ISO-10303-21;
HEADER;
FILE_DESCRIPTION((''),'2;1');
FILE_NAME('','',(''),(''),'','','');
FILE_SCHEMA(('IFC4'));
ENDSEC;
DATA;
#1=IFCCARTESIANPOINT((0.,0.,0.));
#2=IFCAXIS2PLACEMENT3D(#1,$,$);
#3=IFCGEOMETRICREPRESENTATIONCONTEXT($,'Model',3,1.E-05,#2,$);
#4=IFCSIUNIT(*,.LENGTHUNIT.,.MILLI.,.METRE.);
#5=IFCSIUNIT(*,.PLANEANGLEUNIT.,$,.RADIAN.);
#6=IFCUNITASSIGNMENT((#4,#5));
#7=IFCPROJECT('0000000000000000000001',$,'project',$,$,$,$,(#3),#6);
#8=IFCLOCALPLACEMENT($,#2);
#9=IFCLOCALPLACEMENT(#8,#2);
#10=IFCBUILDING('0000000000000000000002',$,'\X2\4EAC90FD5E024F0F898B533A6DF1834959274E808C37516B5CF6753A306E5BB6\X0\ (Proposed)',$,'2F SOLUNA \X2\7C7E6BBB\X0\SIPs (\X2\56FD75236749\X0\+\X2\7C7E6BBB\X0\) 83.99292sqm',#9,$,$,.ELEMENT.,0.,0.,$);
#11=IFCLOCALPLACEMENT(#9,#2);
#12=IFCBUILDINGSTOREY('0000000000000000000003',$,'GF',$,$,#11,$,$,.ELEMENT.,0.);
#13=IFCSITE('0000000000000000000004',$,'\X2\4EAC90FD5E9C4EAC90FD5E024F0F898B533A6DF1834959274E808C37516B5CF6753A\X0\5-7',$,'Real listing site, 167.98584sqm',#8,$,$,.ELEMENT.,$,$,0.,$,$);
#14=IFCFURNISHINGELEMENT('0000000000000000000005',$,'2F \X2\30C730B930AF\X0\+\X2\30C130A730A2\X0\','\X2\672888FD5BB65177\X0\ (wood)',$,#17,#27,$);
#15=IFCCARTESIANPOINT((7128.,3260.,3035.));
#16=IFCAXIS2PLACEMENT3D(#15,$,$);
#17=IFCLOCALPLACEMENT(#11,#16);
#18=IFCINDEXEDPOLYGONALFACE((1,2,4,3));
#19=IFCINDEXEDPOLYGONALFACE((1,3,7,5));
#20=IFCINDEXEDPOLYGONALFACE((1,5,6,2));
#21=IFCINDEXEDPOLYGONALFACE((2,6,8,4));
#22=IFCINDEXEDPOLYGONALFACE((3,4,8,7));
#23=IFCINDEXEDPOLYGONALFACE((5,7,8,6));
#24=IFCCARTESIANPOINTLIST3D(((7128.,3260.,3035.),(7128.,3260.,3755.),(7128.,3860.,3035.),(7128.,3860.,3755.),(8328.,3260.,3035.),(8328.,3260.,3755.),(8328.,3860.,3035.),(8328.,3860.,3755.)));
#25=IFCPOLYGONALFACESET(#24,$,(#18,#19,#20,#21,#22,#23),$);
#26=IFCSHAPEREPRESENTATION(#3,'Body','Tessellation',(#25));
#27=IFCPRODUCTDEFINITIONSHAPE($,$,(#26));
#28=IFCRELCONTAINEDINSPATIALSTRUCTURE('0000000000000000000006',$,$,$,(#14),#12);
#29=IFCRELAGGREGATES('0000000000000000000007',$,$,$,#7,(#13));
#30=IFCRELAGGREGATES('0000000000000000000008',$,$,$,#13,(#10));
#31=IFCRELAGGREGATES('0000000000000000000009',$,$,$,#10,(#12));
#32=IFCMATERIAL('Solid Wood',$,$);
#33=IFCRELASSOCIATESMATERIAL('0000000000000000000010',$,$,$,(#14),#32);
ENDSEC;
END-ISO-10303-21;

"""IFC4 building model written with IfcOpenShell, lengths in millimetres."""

from ifc_helpers import new_model, si_unit, frame, frame_2d, origin, place, context, project, spatial, rectangle, extrude, material, element, save


model = new_model("IFC4")

# Units and contexts
model_context = context("Model", 3, precision=1e-05, world=origin())
ifc_project = project(units=[si_unit("LENGTHUNIT", "METRE", prefix="MILLI"), si_unit("PLANEANGLEUNIT", "RADIAN")], contexts=[model_context])

# Site, building, storey
site_placement = place(None, origin())
site = spatial("IfcSite", under=ifc_project, at=site_placement, Name="京都府京都市伏見区深草大亀谷八島町5-7", ObjectType="Real listing site, 167.98584sqm", CompositionType="ELEMENT", RefElevation=0.0)
building_placement = place(site_placement, origin())
building = spatial("IfcBuilding", under=site, at=building_placement, Name="京都市伏見区深草大亀谷八島町の家 (Proposed)", ObjectType="2F SOLUNA 籾殻SIPs (国産杉+籾殻) 83.99292sqm", CompositionType="ELEMENT", ElevationOfRefHeight=0.0, ElevationOfTerrain=0.0)
storey_placement = place(building_placement, origin())
storey = spatial("IfcBuildingStorey", under=building, at=storey_placement, Name="GF", CompositionType="ELEMENT", Elevation=0.0)

# Shared definitions
ifc_material_1 = material(Name="Solid Wood")

# Furnishing element
furnishing_1_placement = place(storey_placement, frame((7128.0, 3260.0, 3035.0)))
element("IfcFurnishingElement", 1, at=furnishing_1_placement, inside=storey, material=ifc_material_1, Name="2F デスク+チェア", Description="木製家具 (wood)", context=model_context, shape_type="SweptSolid", body=[
    extrude(rectangle(XDim=1200.0, YDim=600.0, at=frame_2d((600.0, 300.0))), frame((7128.0, 3260.0, 3035.0)), (0.0, 0.0, 1.0), 720.0),
])

save(model, "model.ifc")
